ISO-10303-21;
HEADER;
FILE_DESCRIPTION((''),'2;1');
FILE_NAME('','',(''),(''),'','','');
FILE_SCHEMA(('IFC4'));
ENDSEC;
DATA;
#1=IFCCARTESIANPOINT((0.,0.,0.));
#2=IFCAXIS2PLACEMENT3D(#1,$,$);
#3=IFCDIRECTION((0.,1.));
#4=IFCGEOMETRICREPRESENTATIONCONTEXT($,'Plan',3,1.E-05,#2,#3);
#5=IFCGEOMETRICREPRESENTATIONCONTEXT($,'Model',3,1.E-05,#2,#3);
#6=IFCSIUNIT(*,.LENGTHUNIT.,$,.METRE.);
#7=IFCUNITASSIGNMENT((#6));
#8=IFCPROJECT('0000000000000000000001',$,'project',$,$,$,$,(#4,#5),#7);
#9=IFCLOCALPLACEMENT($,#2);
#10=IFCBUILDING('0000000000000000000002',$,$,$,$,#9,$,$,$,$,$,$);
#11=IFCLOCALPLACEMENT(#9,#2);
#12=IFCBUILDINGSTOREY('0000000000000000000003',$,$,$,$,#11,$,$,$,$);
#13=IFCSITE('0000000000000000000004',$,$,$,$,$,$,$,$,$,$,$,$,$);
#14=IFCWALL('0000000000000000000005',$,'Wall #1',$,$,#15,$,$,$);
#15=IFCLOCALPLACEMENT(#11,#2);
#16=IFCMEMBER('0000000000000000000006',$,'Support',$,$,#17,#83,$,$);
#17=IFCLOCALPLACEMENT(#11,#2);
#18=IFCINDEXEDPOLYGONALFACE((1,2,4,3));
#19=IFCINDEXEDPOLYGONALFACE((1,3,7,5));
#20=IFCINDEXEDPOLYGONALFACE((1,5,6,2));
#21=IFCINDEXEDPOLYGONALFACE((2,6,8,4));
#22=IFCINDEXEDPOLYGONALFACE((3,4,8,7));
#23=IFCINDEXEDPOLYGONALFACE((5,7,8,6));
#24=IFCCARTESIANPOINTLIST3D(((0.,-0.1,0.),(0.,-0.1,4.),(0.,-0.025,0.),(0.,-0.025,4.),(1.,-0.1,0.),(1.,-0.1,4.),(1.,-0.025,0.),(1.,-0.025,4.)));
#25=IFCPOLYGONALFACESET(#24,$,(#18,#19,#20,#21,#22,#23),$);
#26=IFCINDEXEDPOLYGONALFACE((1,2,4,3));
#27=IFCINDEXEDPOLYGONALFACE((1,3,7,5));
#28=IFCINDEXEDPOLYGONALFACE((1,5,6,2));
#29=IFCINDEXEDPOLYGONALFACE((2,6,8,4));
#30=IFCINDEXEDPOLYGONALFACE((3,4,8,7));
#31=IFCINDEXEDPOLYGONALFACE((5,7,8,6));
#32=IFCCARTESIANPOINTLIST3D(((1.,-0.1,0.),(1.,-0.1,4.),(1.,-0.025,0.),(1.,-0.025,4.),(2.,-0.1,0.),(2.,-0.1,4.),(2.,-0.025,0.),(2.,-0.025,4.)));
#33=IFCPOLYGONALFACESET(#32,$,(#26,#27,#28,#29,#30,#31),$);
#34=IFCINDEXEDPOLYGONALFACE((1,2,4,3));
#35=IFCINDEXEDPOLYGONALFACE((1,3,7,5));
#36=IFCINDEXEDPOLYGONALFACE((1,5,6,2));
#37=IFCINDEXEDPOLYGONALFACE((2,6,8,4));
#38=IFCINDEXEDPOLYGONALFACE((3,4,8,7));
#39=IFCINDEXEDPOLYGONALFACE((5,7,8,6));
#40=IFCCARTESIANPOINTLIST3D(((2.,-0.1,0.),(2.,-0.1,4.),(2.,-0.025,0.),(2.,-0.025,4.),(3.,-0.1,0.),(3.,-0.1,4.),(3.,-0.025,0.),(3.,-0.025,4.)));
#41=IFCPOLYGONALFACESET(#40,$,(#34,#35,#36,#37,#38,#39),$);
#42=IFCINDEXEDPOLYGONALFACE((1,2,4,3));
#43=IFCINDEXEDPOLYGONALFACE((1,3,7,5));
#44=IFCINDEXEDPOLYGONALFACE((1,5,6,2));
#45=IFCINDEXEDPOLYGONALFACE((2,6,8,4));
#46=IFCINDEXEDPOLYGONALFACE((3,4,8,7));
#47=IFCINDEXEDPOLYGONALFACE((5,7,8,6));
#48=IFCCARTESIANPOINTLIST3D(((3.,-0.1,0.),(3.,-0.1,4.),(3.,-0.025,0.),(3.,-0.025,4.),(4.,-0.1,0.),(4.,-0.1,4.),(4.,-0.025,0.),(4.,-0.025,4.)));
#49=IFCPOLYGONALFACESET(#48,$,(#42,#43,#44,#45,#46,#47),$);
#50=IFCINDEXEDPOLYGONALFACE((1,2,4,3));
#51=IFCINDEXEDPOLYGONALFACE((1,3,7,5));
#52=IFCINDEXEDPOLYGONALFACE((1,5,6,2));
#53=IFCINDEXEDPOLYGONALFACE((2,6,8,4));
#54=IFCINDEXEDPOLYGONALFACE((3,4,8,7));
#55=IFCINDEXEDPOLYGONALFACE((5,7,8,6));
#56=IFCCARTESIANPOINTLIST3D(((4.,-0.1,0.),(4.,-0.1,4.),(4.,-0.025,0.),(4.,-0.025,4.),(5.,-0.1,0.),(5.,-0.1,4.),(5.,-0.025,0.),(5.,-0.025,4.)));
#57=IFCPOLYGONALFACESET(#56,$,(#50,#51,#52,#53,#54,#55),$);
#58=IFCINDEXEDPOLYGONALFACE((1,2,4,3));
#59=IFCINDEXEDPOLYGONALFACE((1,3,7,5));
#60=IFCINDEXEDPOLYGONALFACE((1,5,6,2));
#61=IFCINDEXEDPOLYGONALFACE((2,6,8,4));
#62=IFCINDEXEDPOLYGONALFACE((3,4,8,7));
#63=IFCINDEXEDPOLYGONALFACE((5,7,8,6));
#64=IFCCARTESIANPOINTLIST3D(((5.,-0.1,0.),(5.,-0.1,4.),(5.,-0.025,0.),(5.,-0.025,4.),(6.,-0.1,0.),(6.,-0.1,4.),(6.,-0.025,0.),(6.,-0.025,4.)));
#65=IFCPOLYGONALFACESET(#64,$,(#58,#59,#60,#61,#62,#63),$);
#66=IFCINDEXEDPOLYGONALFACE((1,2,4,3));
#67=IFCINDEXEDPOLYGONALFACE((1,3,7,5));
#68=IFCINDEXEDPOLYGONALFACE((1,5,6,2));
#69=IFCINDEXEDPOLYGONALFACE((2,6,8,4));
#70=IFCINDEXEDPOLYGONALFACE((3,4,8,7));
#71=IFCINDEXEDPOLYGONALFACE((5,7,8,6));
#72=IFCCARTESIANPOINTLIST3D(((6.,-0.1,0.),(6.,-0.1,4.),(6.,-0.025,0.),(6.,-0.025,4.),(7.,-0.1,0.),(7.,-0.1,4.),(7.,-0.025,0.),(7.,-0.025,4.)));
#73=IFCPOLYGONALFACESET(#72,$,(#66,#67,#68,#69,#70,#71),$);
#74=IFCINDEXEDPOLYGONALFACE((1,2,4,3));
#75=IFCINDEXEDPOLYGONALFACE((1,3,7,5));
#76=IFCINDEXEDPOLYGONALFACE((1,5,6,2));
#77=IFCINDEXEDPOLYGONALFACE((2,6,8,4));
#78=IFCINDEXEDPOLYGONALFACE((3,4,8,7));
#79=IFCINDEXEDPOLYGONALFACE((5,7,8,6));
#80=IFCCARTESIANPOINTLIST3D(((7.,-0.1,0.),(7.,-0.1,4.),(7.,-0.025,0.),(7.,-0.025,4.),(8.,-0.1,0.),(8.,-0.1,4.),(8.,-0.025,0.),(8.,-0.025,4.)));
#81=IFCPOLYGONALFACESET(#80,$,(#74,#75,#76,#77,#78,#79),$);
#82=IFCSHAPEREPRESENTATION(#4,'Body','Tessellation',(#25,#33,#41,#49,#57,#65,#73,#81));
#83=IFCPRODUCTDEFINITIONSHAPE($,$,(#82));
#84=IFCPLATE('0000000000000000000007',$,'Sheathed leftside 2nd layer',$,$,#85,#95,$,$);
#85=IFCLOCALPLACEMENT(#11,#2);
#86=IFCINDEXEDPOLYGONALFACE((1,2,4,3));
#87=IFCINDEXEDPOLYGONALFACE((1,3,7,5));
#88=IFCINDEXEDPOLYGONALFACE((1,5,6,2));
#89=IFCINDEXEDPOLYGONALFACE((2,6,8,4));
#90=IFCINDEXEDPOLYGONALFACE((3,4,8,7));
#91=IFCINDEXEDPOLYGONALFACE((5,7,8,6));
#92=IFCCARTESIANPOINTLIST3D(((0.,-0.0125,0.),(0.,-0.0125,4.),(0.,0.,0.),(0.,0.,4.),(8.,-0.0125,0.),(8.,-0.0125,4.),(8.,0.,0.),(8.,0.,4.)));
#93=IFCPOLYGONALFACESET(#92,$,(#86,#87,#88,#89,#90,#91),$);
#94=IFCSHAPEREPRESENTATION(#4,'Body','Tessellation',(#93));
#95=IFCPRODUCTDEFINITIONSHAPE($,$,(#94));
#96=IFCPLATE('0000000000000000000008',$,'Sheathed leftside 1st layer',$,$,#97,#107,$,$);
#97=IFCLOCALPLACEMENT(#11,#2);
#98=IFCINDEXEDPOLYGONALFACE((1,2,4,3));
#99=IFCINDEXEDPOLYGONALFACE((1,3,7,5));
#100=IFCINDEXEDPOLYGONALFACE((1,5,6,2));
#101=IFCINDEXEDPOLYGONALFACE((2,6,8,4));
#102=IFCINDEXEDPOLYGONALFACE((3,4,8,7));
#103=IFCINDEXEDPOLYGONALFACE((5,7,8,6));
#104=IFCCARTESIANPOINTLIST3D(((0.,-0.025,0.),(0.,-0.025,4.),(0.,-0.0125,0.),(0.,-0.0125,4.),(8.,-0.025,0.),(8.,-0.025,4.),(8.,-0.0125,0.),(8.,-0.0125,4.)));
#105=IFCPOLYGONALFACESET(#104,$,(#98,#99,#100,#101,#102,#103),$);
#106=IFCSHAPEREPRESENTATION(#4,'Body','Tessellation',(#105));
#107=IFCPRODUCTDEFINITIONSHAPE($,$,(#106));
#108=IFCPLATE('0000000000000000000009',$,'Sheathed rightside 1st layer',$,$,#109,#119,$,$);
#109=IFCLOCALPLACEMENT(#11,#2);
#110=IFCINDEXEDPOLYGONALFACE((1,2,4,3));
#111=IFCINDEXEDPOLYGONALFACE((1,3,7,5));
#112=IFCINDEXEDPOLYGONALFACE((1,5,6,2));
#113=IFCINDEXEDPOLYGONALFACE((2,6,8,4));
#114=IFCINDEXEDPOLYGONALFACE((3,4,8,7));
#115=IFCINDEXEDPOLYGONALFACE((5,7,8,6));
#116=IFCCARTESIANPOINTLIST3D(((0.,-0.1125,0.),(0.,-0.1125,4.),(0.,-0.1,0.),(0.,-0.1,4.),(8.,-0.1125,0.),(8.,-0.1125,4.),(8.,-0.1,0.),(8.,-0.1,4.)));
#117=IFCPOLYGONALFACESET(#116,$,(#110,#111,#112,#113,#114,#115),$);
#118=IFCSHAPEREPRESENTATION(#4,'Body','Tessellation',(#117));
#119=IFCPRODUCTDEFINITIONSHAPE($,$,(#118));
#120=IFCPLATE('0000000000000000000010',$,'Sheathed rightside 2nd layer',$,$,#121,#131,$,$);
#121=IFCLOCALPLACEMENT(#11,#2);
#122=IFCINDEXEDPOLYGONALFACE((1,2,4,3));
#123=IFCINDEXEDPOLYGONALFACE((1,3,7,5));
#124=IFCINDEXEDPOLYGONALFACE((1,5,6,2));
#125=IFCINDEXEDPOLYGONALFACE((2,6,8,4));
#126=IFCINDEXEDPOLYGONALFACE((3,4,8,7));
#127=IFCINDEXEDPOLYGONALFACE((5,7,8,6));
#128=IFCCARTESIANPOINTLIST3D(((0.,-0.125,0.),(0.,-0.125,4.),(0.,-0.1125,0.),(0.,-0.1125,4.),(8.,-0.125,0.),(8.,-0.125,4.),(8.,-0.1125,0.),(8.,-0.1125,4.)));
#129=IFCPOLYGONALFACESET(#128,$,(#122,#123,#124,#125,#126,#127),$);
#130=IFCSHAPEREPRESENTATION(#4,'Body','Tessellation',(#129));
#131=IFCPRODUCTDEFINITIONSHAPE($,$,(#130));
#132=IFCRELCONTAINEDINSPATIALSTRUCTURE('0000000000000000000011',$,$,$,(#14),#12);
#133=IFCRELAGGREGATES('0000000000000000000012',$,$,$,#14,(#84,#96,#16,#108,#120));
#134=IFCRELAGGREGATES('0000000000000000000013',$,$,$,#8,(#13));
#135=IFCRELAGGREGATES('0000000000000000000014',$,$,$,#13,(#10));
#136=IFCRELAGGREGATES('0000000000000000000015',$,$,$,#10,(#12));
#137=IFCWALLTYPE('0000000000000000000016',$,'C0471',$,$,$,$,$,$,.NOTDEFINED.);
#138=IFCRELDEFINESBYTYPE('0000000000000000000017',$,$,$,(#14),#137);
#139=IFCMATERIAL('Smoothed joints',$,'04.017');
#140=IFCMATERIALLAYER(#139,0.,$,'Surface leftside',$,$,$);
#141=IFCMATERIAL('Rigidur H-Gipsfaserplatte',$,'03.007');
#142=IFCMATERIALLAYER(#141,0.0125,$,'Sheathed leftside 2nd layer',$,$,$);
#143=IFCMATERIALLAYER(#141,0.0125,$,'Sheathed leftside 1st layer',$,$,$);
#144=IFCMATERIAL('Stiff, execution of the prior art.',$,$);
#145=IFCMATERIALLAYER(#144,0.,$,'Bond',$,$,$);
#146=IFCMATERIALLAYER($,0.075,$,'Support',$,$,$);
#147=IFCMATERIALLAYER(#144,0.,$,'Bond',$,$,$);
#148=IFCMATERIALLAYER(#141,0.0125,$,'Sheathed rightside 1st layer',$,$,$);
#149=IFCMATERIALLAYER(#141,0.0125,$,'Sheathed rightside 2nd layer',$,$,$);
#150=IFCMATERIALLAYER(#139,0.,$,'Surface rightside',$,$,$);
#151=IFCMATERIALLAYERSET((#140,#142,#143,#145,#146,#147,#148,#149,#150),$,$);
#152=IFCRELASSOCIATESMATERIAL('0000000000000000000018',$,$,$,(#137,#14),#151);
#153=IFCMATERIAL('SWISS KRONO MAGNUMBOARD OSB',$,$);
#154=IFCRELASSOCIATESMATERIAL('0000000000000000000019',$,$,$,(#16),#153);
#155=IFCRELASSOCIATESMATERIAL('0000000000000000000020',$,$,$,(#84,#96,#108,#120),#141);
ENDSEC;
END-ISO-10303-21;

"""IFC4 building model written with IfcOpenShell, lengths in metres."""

from ifc_helpers import new_model, si_unit, direction, frame, frame_2d, origin, origin_with_axes, place, context, project, spatial, rectangle, extrude, material, layer, layer_set, type_object, element, aggregate, save


model = new_model("IFC4")

# Units and contexts
plan_context = context("Plan", 3, precision=1e-05, world=origin(), true_north=direction((0.0, 1.0)))
model_context = context("Model", 3, precision=1e-05, world=origin(), true_north=direction((0.0, 1.0)))
ifc_project = project(units=[si_unit("LENGTHUNIT", "METRE")], contexts=[plan_context, model_context])

# Site, building, storey
site = spatial("IfcSite", under=ifc_project)
building_placement = place(None, origin())
building = spatial("IfcBuilding", under=site, at=building_placement)
storey_placement = place(building_placement, origin())
storey = spatial("IfcBuildingStorey", under=building, at=storey_placement)

# Wall, member, plates
ifc_material_1 = material(Name="Smoothed joints", Category="04.017")
ifc_layer_1 = layer(ifc_material_1, 0.0, Name="Surface leftside")
ifc_material_2 = material(Name="Rigidur H-Gipsfaserplatte", Category="03.007")
ifc_layer_2 = layer(ifc_material_2, 0.0125, Name="Sheathed leftside 2nd layer")
ifc_layer_3 = layer(ifc_material_2, 0.0125, Name="Sheathed leftside 1st layer")
ifc_material_3 = material(Name="Stiff, execution of the prior art.")
ifc_layer_4 = layer(ifc_material_3, 0.0, Name="Bond")
ifc_layer_5 = layer(None, 0.075, Name="Support")
ifc_layer_6 = layer(ifc_material_3, 0.0, Name="Bond")
ifc_layer_7 = layer(ifc_material_2, 0.0125, Name="Sheathed rightside 1st layer")
ifc_layer_8 = layer(ifc_material_2, 0.0125, Name="Sheathed rightside 2nd layer")
ifc_layer_9 = layer(ifc_material_1, 0.0, Name="Surface rightside")
ifc_layer_set = layer_set([ifc_layer_1, ifc_layer_2, ifc_layer_3, ifc_layer_4, ifc_layer_5, ifc_layer_6, ifc_layer_7, ifc_layer_8, ifc_layer_9])
wall_type = type_object("IfcWallType", Name="C0471", PredefinedType="NOTDEFINED", material=ifc_layer_set)
wall_placement = place(None, frame((0.0, 0.0, 0.0), z_axis=(0.0, -1.0, 0.0), x_axis=(1.0, 0.0, 0.0)))
wall = element("IfcWall", 1, at=wall_placement, inside=storey, type_object=wall_type, material=ifc_layer_set, Name="Wall #1")
ifc_material_4 = material(Name="SWISS KRONO MAGNUMBOARD OSB")
member_placement = place(wall_placement, origin())
member = element("IfcMember", 2, at=member_placement, material=ifc_material_4, Name="Support", context=plan_context, shape_type="SweptSolid", body=[
    extrude(rectangle(XDim=1.0, YDim=0.075, at=frame_2d((0.5, 0.0375), x_axis=(1.0, 0.0))), frame((0.0, 4.0, 0.025), z_axis=(0.0, -1.0, 0.0), x_axis=(1.0, 0.0, 0.0)), (0.0, 0.0, 1.0), 4.0),
    extrude(rectangle(XDim=1.0, YDim=0.075, at=frame_2d((0.5, 0.0375), x_axis=(1.0, 0.0))), frame((1.0, 4.0, 0.025), z_axis=(0.0, -1.0, 0.0), x_axis=(1.0, 0.0, 0.0)), (0.0, 0.0, 1.0), 4.0),
    extrude(rectangle(XDim=1.0, YDim=0.075, at=frame_2d((0.5, 0.0375), x_axis=(1.0, 0.0))), frame((2.0, 4.0, 0.025), z_axis=(0.0, -1.0, 0.0), x_axis=(1.0, 0.0, 0.0)), (0.0, 0.0, 1.0), 4.0),
    extrude(rectangle(XDim=1.0, YDim=0.075, at=frame_2d((0.5, 0.0375), x_axis=(1.0, 0.0))), frame((3.0, 4.0, 0.025), z_axis=(0.0, -1.0, 0.0), x_axis=(1.0, 0.0, 0.0)), (0.0, 0.0, 1.0), 4.0),
    extrude(rectangle(XDim=1.0, YDim=0.075, at=frame_2d((0.5, 0.0375), x_axis=(1.0, 0.0))), frame((4.0, 4.0, 0.025), z_axis=(0.0, -1.0, 0.0), x_axis=(1.0, 0.0, 0.0)), (0.0, 0.0, 1.0), 4.0),
    extrude(rectangle(XDim=1.0, YDim=0.075, at=frame_2d((0.5, 0.0375), x_axis=(1.0, 0.0))), frame((5.0, 4.0, 0.025), z_axis=(0.0, -1.0, 0.0), x_axis=(1.0, 0.0, 0.0)), (0.0, 0.0, 1.0), 4.0),
    extrude(rectangle(XDim=1.0, YDim=0.075, at=frame_2d((0.5, 0.0375), x_axis=(1.0, 0.0))), frame((6.0, 4.0, 0.025), z_axis=(0.0, -1.0, 0.0), x_axis=(1.0, 0.0, 0.0)), (0.0, 0.0, 1.0), 4.0),
    extrude(rectangle(XDim=1.0, YDim=0.075, at=frame_2d((0.5, 0.0375), x_axis=(1.0, 0.0))), frame((7.0, 4.0, 0.025), z_axis=(0.0, -1.0, 0.0), x_axis=(1.0, 0.0, 0.0)), (0.0, 0.0, 1.0), 4.0),
])
plate_1_placement = place(wall_placement, origin())
plate_1 = element("IfcPlate", 3, at=plate_1_placement, material=ifc_material_2, Name="Sheathed leftside 2nd layer", context=plan_context, shape_type="SweptSolid", body=[
    extrude(rectangle(XDim=8.0, YDim=4.0, at=frame_2d((4.0, 2.0), x_axis=(1.0, 0.0))), origin_with_axes(), (0.0, 0.0, 1.0), 0.0125),
])
plate_2_placement = place(wall_placement, origin())
plate_2 = element("IfcPlate", 4, at=plate_2_placement, material=ifc_material_2, Name="Sheathed leftside 1st layer", context=plan_context, shape_type="SweptSolid", body=[
    extrude(rectangle(XDim=8.0, YDim=4.0, at=frame_2d((4.0, 2.0), x_axis=(1.0, 0.0))), frame((0.0, 0.0, 0.0125), z_axis=(0.0, 0.0, 1.0), x_axis=(1.0, 0.0, 0.0)), (0.0, 0.0, 1.0), 0.0125),
])
plate_3_placement = place(wall_placement, origin())
plate_3 = element("IfcPlate", 5, at=plate_3_placement, material=ifc_material_2, Name="Sheathed rightside 1st layer", context=plan_context, shape_type="SweptSolid", body=[
    extrude(rectangle(XDim=8.0, YDim=4.0, at=frame_2d((4.0, 2.0), x_axis=(1.0, 0.0))), frame((0.0, 0.0, 0.1), z_axis=(0.0, 0.0, 1.0), x_axis=(1.0, 0.0, 0.0)), (0.0, 0.0, 1.0), 0.0125),
])
plate_4_placement = place(wall_placement, origin())
plate_4 = element("IfcPlate", 6, at=plate_4_placement, material=ifc_material_2, Name="Sheathed rightside 2nd layer", context=plan_context, shape_type="SweptSolid", body=[
    extrude(rectangle(XDim=8.0, YDim=4.0, at=frame_2d((4.0, 2.0), x_axis=(1.0, 0.0))), frame((0.0, 0.0, 0.1125), z_axis=(0.0, 0.0, 1.0), x_axis=(1.0, 0.0, 0.0)), (0.0, 0.0, 1.0), 0.0125),
])
aggregate(wall, [plate_1, plate_2, member, plate_3, plate_4])

save(model, "model.ifc")
